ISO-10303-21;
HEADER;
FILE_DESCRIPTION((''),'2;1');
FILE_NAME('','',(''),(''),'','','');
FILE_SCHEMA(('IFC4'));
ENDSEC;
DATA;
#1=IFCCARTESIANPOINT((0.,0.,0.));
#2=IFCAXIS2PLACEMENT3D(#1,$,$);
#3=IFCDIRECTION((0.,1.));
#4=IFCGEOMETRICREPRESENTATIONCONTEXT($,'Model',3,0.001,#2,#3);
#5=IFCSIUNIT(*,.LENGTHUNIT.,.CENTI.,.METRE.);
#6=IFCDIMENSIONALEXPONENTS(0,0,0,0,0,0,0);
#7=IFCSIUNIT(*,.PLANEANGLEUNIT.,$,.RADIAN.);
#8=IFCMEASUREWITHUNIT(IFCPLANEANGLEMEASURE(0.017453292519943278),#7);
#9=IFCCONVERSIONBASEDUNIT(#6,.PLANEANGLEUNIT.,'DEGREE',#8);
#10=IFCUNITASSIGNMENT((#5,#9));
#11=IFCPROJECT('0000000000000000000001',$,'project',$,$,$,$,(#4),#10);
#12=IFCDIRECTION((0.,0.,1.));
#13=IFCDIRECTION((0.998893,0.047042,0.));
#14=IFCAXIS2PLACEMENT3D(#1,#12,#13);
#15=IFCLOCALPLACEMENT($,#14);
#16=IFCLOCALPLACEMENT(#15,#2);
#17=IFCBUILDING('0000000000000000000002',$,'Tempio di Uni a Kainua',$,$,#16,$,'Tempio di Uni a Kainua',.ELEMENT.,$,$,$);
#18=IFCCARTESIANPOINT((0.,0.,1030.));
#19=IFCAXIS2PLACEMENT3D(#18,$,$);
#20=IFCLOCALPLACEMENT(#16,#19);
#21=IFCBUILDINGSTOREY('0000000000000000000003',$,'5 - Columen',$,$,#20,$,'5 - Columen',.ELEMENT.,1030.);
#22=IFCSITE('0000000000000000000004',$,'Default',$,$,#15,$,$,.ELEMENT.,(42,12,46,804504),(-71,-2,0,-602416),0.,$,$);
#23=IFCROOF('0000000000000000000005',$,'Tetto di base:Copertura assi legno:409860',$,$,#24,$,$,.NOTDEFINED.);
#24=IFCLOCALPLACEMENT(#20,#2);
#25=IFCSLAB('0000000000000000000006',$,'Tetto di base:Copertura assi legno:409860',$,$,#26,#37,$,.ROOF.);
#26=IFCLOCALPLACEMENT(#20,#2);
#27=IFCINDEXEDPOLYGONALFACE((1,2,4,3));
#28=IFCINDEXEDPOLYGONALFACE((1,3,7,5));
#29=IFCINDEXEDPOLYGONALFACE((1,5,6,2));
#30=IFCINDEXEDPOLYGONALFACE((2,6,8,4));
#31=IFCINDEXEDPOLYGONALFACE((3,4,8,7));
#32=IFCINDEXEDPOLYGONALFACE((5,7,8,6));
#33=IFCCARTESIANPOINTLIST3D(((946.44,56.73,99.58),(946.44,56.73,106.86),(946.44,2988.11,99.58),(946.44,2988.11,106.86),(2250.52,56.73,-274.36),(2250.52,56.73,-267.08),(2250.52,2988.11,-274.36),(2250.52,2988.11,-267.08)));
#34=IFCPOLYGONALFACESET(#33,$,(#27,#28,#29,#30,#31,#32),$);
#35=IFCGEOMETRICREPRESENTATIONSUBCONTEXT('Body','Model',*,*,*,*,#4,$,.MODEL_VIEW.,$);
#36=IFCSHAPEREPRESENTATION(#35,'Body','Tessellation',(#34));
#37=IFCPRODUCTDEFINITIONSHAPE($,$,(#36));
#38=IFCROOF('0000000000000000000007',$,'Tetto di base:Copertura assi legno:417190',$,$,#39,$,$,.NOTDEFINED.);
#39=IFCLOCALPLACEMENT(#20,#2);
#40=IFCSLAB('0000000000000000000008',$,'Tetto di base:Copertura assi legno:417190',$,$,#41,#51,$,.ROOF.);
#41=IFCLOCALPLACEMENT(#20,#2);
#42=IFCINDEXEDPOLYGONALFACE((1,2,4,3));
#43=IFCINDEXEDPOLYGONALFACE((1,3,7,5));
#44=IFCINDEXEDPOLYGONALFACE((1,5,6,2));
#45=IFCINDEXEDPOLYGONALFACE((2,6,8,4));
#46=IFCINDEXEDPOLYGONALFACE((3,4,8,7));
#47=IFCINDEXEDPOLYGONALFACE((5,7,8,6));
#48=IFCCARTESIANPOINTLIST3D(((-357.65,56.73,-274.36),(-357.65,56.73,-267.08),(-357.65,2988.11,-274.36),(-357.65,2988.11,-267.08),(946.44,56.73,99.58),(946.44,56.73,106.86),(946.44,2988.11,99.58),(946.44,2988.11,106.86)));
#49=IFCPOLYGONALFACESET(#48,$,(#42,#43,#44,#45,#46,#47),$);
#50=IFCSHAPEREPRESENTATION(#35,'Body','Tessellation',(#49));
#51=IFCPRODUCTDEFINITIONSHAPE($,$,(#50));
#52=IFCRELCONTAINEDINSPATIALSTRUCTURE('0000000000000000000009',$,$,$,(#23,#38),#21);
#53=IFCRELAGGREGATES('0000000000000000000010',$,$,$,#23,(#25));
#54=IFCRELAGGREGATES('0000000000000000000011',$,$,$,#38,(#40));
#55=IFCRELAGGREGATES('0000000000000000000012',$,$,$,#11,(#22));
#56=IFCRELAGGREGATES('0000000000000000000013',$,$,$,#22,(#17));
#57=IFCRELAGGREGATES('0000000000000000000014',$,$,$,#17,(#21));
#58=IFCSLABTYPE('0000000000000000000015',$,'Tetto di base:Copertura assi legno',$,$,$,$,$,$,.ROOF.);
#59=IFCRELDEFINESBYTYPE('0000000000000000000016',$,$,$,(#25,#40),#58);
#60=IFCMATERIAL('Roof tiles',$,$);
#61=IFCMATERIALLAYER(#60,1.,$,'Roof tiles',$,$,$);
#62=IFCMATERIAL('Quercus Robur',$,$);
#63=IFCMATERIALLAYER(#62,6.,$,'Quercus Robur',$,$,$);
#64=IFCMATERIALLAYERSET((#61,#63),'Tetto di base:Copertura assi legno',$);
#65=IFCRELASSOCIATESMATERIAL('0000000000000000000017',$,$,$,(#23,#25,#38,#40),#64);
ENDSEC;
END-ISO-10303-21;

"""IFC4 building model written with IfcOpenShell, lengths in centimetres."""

from ifc_helpers import new_model, entity, si_unit, converted_unit, direction, frame, frame_2d, origin, place, context, subcontext, project, spatial, rectangle, extrude, material, layer, layer_set, type_object, element, aggregate, save


model = new_model("IFC4")

# Units and contexts
model_context = context("Model", 3, precision=0.001, world=origin(), true_north=direction((0.0, 1.0)))
body_context = subcontext(model_context, "Body", "Model", "MODEL_VIEW")
ifc_project = project(units=[si_unit("LENGTHUNIT", "METRE", prefix="CENTI"), converted_unit("PLANEANGLEUNIT", "DEGREE", entity("IfcPlaneAngleMeasure", 0.017453292519943278), si_unit("PLANEANGLEUNIT", "RADIAN"), dimensions=[0, 0, 0, 0, 0, 0, 0])], contexts=[model_context])

# Site, building, storey
site_placement = place(None, frame((0.0, 0.0, 0.0), z_axis=(0.0, 0.0, 1.0), x_axis=(0.998893, 0.047042, 0.0)))
site = spatial("IfcSite", under=ifc_project, at=site_placement, Name="Default", CompositionType="ELEMENT", RefLatitude=(42, 12, 46, 804504), RefLongitude=(-71, -2, 0, -602416), RefElevation=0.0)
building_placement = place(site_placement, origin())
building = spatial("IfcBuilding", under=site, at=building_placement, Name="Tempio di Uni a Kainua", LongName="Tempio di Uni a Kainua", CompositionType="ELEMENT")
storey_placement = place(building_placement, frame((0.0, 0.0, 1030.0)))
storey = spatial("IfcBuildingStorey", under=building, at=storey_placement, Name="5 - Columen", LongName="5 - Columen", CompositionType="ELEMENT", Elevation=1030.0)

# Shared definitions
ifc_material_1 = material(Name="Quercus Robur")

# Roofs, slabs
ifc_material_2 = material(Name="Roof tiles")
ifc_layer_1 = layer(ifc_material_2, 1.0, Name="Roof tiles")
ifc_layer_2 = layer(ifc_material_1, 6.0, Name="Quercus Robur")
ifc_layer_set = layer_set([ifc_layer_1, ifc_layer_2], Name="Tetto di base:Copertura assi legno")
roof_1_placement = place(storey_placement, frame((946.44, 56.73, -274.36)))
roof_1 = element("IfcRoof", 1, at=roof_1_placement, inside=storey, material=ifc_layer_set, Name="Tetto di base:Copertura assi legno:409860", PredefinedType="NOTDEFINED")
slab_type = type_object("IfcSlabType", Name="Tetto di base:Copertura assi legno", PredefinedType="ROOF")
slab_1_placement = place(roof_1_placement, origin())
slab_1 = element("IfcSlab", 2, at=slab_1_placement, type_object=slab_type, material=ifc_layer_set, Name="Tetto di base:Copertura assi legno:409860", PredefinedType="ROOF", context=body_context, shape_type="SweptSolid", body=[
    extrude(rectangle(XDim=1356.64, YDim=2931.37, at=frame_2d((0.0, 0.0), x_axis=(-1.0, 0.0))), frame((652.04, 1465.69, 186.97), z_axis=(0.275637, 0.0, 0.961262), x_axis=(0.961262, 0.0, -0.275637)), (-0.275637, 0.0, 0.961262), 7.28),
])
aggregate(roof_1, [slab_1])
roof_2_placement = place(storey_placement, frame((-357.65, 56.73, -274.36)))
roof_2 = element("IfcRoof", 3, at=roof_2_placement, inside=storey, material=ifc_layer_set, Name="Tetto di base:Copertura assi legno:417190", PredefinedType="NOTDEFINED")
slab_2_placement = place(roof_2_placement, origin())
slab_2 = element("IfcSlab", 4, at=slab_2_placement, type_object=slab_type, material=ifc_layer_set, Name="Tetto di base:Copertura assi legno:417190", PredefinedType="ROOF", context=body_context, shape_type="SweptSolid", body=[
    extrude(rectangle(XDim=1356.64, YDim=2931.37, at=frame_2d((0.0, 0.0), x_axis=(1.0, 0.0))), frame((652.04, 1465.69, 186.97), z_axis=(-0.275637, 0.0, 0.961262), x_axis=(0.961262, 0.0, 0.275637)), (0.275637, 0.0, 0.961262), 7.28),
])
aggregate(roof_2, [slab_2])

save(model, "model.ifc")
